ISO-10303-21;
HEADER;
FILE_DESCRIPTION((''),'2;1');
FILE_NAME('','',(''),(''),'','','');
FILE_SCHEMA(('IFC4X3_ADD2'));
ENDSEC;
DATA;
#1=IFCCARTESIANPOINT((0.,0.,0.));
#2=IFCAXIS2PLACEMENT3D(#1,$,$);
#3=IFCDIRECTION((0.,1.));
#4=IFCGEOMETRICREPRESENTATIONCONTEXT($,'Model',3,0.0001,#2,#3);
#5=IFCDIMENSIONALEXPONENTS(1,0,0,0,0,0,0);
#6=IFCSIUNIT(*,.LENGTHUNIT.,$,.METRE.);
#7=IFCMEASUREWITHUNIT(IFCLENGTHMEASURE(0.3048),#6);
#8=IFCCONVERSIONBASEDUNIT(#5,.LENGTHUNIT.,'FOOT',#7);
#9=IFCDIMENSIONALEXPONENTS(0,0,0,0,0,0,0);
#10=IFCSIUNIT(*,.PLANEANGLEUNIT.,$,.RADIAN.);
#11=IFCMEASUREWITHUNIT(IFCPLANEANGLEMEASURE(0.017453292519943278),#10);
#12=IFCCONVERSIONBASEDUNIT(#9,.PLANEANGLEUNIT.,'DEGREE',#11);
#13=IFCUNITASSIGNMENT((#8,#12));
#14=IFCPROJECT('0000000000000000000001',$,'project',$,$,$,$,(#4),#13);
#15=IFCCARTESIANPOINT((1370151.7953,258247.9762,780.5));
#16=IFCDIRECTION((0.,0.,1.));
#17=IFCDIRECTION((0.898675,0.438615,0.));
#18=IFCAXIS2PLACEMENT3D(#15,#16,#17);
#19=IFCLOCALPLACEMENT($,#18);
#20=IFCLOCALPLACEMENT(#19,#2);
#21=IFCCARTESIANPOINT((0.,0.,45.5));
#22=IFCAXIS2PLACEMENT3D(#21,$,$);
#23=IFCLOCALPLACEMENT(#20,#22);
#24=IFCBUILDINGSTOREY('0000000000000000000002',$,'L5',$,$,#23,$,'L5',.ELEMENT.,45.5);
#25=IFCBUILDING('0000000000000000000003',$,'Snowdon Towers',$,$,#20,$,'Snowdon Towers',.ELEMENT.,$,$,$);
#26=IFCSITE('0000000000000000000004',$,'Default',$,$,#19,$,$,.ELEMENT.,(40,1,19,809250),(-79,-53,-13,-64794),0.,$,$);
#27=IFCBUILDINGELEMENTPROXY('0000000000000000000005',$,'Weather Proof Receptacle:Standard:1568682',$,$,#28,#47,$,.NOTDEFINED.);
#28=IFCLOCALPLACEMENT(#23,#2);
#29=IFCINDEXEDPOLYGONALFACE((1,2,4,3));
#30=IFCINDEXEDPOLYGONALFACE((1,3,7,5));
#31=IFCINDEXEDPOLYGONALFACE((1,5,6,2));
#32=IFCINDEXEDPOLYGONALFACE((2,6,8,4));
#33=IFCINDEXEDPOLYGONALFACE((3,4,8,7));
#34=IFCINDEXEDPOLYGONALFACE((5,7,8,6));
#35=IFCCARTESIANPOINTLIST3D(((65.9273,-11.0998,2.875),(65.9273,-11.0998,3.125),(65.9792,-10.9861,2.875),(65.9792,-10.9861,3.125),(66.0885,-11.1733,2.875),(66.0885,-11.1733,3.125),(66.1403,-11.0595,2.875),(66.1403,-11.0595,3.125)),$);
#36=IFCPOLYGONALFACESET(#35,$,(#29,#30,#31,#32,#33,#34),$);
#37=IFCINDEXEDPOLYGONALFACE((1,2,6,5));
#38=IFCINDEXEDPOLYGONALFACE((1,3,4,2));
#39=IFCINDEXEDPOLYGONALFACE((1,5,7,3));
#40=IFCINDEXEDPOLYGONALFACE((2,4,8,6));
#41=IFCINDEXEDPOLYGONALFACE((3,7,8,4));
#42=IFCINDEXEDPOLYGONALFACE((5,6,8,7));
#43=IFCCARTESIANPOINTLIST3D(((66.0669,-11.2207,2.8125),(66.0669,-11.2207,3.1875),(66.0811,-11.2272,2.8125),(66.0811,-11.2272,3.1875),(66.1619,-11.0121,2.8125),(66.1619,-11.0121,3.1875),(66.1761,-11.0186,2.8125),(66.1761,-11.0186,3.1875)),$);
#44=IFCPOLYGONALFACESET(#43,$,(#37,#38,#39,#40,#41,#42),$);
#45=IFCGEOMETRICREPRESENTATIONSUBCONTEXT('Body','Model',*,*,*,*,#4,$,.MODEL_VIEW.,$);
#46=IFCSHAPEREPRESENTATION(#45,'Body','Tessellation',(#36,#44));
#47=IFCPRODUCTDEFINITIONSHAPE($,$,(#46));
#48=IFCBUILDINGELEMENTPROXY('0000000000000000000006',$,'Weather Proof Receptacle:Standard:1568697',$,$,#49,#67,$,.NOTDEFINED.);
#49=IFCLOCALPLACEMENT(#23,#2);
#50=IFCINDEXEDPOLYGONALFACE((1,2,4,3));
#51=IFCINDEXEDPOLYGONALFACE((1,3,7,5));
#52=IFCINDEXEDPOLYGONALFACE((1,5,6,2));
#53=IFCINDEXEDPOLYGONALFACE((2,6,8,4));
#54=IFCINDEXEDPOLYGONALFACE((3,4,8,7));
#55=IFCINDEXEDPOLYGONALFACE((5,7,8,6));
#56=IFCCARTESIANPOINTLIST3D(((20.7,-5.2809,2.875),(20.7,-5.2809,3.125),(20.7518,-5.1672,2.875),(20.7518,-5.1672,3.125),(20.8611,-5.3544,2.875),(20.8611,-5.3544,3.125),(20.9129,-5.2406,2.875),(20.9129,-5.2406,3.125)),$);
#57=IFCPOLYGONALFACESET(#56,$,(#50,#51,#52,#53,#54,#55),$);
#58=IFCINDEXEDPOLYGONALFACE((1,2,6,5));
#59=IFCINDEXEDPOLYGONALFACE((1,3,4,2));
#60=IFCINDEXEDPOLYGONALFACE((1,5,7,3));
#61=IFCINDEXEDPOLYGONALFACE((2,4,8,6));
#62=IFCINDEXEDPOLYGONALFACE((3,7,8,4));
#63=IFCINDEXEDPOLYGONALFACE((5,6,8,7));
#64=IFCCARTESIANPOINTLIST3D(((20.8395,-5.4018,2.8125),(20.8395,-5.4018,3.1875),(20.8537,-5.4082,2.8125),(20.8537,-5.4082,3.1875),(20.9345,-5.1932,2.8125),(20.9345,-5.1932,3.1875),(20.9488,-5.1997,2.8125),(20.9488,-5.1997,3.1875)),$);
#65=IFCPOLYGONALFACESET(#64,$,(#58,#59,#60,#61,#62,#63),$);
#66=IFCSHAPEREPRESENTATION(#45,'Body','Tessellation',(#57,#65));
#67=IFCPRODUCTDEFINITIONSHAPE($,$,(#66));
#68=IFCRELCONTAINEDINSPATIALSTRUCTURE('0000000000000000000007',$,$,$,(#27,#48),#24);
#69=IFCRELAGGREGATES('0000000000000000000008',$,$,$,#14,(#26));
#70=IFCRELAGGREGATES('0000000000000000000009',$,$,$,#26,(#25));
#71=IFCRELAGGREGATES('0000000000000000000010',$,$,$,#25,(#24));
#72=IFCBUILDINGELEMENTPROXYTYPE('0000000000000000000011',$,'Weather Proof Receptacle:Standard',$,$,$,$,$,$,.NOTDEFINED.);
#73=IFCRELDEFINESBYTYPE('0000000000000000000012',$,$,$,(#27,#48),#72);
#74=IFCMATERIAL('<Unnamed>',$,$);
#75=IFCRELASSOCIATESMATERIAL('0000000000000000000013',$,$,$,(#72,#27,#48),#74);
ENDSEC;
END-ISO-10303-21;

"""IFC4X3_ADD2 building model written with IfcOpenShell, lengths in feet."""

from ifc_helpers import new_model, entity, si_unit, converted_unit, direction, frame, frame_2d, origin, origin_2d_with_axis, place, context, subcontext, project, spatial, rectangle, extrude, source, transform, mapped, material, type_object, type_shapes, element, save


model = new_model("IFC4X3_ADD2")

# Units and contexts
model_context = context("Model", 3, precision=0.0001, world=origin(), true_north=direction((0.0, 1.0)))
body_context = subcontext(model_context, "Body", "Model", "MODEL_VIEW")
ifc_project = project(units=[converted_unit("LENGTHUNIT", "FOOT", entity("IfcLengthMeasure", 0.3048), si_unit("LENGTHUNIT", "METRE"), dimensions=[1, 0, 0, 0, 0, 0, 0]), converted_unit("PLANEANGLEUNIT", "DEGREE", entity("IfcPlaneAngleMeasure", 0.017453292519943278), si_unit("PLANEANGLEUNIT", "RADIAN"), dimensions=[0, 0, 0, 0, 0, 0, 0])], contexts=[model_context])

# Site, building, storey
site_placement = place(None, frame((1370151.7953, 258247.9762, 780.5), z_axis=(0.0, 0.0, 1.0), x_axis=(0.898675, 0.438615, 0.0)))
site = spatial("IfcSite", under=ifc_project, at=site_placement, Name="Default", CompositionType="ELEMENT", RefLatitude=(40, 1, 19, 809250), RefLongitude=(-79, -53, -13, -64794), RefElevation=0.0)
building_placement = place(site_placement, origin())
building = spatial("IfcBuilding", under=site, at=building_placement, Name="Snowdon Towers", LongName="Snowdon Towers", CompositionType="ELEMENT")
storey_placement = place(building_placement, frame((0.0, 0.0, 45.5)))
storey = spatial("IfcBuildingStorey", under=building, at=storey_placement, Name="L5", LongName="L5", CompositionType="ELEMENT", Elevation=45.5)

# Shared definitions
ifc_material_1 = material(Name="<Unnamed>")

# Building element proxies
building_element_proxy_type_1 = type_object("IfcBuildingElementProxyType", Name="Weather Proof Receptacle:Standard", PredefinedType="NOTDEFINED", material=ifc_material_1)
shared_shape_1 = source(origin(), body_context, "Body", "SweptSolid", [
    extrude(rectangle(XDim=0.125, YDim=0.25, at=origin_2d_with_axis()), frame((0.0, 0.0, -0.1771), z_axis=(0.0, 0.0, 1.0), x_axis=(-1.0, 0.0, 0.0)), (0.0, 0.0, 1.0), 0.1771),
    extrude(rectangle(XDim=0.2292, YDim=0.375, at=frame_2d((0.0, 0.0), x_axis=(1.0, 0.0))), frame((0.0, 0.0, 0.0), z_axis=(0.0, 0.0, 1.0), x_axis=(-1.0, 0.0, 0.0)), (0.0, 0.0, 1.0), 0.0156),
])
type_shapes(building_element_proxy_type_1, [shared_shape_1])
for number, where, z_axis, x_axis, name in (
    (1, (66.1144, -11.1164, 3.0), (0.909972, -0.414671, 0.0), (0.414671, 0.909972, 0.0), "Weather Proof Receptacle:Standard:1568682"),
    (2, (20.887, -5.2975, 3.0), (0.909972, -0.414671, 0.0), (-0.414671, -0.909972, 0.0), "Weather Proof Receptacle:Standard:1568697"),
):
    element("IfcBuildingElementProxy", number, at=place(storey_placement, frame(where, z_axis=z_axis, x_axis=x_axis)), inside=storey, type_object=building_element_proxy_type_1, material=ifc_material_1, Name=name, PredefinedType="NOTDEFINED", context=body_context, shape_type="MappedRepresentation", body=[
        mapped(shared_shape_1, transform((0.0, 0.0, 0.0), scale=1.0)),
    ])

save(model, "model.ifc")
